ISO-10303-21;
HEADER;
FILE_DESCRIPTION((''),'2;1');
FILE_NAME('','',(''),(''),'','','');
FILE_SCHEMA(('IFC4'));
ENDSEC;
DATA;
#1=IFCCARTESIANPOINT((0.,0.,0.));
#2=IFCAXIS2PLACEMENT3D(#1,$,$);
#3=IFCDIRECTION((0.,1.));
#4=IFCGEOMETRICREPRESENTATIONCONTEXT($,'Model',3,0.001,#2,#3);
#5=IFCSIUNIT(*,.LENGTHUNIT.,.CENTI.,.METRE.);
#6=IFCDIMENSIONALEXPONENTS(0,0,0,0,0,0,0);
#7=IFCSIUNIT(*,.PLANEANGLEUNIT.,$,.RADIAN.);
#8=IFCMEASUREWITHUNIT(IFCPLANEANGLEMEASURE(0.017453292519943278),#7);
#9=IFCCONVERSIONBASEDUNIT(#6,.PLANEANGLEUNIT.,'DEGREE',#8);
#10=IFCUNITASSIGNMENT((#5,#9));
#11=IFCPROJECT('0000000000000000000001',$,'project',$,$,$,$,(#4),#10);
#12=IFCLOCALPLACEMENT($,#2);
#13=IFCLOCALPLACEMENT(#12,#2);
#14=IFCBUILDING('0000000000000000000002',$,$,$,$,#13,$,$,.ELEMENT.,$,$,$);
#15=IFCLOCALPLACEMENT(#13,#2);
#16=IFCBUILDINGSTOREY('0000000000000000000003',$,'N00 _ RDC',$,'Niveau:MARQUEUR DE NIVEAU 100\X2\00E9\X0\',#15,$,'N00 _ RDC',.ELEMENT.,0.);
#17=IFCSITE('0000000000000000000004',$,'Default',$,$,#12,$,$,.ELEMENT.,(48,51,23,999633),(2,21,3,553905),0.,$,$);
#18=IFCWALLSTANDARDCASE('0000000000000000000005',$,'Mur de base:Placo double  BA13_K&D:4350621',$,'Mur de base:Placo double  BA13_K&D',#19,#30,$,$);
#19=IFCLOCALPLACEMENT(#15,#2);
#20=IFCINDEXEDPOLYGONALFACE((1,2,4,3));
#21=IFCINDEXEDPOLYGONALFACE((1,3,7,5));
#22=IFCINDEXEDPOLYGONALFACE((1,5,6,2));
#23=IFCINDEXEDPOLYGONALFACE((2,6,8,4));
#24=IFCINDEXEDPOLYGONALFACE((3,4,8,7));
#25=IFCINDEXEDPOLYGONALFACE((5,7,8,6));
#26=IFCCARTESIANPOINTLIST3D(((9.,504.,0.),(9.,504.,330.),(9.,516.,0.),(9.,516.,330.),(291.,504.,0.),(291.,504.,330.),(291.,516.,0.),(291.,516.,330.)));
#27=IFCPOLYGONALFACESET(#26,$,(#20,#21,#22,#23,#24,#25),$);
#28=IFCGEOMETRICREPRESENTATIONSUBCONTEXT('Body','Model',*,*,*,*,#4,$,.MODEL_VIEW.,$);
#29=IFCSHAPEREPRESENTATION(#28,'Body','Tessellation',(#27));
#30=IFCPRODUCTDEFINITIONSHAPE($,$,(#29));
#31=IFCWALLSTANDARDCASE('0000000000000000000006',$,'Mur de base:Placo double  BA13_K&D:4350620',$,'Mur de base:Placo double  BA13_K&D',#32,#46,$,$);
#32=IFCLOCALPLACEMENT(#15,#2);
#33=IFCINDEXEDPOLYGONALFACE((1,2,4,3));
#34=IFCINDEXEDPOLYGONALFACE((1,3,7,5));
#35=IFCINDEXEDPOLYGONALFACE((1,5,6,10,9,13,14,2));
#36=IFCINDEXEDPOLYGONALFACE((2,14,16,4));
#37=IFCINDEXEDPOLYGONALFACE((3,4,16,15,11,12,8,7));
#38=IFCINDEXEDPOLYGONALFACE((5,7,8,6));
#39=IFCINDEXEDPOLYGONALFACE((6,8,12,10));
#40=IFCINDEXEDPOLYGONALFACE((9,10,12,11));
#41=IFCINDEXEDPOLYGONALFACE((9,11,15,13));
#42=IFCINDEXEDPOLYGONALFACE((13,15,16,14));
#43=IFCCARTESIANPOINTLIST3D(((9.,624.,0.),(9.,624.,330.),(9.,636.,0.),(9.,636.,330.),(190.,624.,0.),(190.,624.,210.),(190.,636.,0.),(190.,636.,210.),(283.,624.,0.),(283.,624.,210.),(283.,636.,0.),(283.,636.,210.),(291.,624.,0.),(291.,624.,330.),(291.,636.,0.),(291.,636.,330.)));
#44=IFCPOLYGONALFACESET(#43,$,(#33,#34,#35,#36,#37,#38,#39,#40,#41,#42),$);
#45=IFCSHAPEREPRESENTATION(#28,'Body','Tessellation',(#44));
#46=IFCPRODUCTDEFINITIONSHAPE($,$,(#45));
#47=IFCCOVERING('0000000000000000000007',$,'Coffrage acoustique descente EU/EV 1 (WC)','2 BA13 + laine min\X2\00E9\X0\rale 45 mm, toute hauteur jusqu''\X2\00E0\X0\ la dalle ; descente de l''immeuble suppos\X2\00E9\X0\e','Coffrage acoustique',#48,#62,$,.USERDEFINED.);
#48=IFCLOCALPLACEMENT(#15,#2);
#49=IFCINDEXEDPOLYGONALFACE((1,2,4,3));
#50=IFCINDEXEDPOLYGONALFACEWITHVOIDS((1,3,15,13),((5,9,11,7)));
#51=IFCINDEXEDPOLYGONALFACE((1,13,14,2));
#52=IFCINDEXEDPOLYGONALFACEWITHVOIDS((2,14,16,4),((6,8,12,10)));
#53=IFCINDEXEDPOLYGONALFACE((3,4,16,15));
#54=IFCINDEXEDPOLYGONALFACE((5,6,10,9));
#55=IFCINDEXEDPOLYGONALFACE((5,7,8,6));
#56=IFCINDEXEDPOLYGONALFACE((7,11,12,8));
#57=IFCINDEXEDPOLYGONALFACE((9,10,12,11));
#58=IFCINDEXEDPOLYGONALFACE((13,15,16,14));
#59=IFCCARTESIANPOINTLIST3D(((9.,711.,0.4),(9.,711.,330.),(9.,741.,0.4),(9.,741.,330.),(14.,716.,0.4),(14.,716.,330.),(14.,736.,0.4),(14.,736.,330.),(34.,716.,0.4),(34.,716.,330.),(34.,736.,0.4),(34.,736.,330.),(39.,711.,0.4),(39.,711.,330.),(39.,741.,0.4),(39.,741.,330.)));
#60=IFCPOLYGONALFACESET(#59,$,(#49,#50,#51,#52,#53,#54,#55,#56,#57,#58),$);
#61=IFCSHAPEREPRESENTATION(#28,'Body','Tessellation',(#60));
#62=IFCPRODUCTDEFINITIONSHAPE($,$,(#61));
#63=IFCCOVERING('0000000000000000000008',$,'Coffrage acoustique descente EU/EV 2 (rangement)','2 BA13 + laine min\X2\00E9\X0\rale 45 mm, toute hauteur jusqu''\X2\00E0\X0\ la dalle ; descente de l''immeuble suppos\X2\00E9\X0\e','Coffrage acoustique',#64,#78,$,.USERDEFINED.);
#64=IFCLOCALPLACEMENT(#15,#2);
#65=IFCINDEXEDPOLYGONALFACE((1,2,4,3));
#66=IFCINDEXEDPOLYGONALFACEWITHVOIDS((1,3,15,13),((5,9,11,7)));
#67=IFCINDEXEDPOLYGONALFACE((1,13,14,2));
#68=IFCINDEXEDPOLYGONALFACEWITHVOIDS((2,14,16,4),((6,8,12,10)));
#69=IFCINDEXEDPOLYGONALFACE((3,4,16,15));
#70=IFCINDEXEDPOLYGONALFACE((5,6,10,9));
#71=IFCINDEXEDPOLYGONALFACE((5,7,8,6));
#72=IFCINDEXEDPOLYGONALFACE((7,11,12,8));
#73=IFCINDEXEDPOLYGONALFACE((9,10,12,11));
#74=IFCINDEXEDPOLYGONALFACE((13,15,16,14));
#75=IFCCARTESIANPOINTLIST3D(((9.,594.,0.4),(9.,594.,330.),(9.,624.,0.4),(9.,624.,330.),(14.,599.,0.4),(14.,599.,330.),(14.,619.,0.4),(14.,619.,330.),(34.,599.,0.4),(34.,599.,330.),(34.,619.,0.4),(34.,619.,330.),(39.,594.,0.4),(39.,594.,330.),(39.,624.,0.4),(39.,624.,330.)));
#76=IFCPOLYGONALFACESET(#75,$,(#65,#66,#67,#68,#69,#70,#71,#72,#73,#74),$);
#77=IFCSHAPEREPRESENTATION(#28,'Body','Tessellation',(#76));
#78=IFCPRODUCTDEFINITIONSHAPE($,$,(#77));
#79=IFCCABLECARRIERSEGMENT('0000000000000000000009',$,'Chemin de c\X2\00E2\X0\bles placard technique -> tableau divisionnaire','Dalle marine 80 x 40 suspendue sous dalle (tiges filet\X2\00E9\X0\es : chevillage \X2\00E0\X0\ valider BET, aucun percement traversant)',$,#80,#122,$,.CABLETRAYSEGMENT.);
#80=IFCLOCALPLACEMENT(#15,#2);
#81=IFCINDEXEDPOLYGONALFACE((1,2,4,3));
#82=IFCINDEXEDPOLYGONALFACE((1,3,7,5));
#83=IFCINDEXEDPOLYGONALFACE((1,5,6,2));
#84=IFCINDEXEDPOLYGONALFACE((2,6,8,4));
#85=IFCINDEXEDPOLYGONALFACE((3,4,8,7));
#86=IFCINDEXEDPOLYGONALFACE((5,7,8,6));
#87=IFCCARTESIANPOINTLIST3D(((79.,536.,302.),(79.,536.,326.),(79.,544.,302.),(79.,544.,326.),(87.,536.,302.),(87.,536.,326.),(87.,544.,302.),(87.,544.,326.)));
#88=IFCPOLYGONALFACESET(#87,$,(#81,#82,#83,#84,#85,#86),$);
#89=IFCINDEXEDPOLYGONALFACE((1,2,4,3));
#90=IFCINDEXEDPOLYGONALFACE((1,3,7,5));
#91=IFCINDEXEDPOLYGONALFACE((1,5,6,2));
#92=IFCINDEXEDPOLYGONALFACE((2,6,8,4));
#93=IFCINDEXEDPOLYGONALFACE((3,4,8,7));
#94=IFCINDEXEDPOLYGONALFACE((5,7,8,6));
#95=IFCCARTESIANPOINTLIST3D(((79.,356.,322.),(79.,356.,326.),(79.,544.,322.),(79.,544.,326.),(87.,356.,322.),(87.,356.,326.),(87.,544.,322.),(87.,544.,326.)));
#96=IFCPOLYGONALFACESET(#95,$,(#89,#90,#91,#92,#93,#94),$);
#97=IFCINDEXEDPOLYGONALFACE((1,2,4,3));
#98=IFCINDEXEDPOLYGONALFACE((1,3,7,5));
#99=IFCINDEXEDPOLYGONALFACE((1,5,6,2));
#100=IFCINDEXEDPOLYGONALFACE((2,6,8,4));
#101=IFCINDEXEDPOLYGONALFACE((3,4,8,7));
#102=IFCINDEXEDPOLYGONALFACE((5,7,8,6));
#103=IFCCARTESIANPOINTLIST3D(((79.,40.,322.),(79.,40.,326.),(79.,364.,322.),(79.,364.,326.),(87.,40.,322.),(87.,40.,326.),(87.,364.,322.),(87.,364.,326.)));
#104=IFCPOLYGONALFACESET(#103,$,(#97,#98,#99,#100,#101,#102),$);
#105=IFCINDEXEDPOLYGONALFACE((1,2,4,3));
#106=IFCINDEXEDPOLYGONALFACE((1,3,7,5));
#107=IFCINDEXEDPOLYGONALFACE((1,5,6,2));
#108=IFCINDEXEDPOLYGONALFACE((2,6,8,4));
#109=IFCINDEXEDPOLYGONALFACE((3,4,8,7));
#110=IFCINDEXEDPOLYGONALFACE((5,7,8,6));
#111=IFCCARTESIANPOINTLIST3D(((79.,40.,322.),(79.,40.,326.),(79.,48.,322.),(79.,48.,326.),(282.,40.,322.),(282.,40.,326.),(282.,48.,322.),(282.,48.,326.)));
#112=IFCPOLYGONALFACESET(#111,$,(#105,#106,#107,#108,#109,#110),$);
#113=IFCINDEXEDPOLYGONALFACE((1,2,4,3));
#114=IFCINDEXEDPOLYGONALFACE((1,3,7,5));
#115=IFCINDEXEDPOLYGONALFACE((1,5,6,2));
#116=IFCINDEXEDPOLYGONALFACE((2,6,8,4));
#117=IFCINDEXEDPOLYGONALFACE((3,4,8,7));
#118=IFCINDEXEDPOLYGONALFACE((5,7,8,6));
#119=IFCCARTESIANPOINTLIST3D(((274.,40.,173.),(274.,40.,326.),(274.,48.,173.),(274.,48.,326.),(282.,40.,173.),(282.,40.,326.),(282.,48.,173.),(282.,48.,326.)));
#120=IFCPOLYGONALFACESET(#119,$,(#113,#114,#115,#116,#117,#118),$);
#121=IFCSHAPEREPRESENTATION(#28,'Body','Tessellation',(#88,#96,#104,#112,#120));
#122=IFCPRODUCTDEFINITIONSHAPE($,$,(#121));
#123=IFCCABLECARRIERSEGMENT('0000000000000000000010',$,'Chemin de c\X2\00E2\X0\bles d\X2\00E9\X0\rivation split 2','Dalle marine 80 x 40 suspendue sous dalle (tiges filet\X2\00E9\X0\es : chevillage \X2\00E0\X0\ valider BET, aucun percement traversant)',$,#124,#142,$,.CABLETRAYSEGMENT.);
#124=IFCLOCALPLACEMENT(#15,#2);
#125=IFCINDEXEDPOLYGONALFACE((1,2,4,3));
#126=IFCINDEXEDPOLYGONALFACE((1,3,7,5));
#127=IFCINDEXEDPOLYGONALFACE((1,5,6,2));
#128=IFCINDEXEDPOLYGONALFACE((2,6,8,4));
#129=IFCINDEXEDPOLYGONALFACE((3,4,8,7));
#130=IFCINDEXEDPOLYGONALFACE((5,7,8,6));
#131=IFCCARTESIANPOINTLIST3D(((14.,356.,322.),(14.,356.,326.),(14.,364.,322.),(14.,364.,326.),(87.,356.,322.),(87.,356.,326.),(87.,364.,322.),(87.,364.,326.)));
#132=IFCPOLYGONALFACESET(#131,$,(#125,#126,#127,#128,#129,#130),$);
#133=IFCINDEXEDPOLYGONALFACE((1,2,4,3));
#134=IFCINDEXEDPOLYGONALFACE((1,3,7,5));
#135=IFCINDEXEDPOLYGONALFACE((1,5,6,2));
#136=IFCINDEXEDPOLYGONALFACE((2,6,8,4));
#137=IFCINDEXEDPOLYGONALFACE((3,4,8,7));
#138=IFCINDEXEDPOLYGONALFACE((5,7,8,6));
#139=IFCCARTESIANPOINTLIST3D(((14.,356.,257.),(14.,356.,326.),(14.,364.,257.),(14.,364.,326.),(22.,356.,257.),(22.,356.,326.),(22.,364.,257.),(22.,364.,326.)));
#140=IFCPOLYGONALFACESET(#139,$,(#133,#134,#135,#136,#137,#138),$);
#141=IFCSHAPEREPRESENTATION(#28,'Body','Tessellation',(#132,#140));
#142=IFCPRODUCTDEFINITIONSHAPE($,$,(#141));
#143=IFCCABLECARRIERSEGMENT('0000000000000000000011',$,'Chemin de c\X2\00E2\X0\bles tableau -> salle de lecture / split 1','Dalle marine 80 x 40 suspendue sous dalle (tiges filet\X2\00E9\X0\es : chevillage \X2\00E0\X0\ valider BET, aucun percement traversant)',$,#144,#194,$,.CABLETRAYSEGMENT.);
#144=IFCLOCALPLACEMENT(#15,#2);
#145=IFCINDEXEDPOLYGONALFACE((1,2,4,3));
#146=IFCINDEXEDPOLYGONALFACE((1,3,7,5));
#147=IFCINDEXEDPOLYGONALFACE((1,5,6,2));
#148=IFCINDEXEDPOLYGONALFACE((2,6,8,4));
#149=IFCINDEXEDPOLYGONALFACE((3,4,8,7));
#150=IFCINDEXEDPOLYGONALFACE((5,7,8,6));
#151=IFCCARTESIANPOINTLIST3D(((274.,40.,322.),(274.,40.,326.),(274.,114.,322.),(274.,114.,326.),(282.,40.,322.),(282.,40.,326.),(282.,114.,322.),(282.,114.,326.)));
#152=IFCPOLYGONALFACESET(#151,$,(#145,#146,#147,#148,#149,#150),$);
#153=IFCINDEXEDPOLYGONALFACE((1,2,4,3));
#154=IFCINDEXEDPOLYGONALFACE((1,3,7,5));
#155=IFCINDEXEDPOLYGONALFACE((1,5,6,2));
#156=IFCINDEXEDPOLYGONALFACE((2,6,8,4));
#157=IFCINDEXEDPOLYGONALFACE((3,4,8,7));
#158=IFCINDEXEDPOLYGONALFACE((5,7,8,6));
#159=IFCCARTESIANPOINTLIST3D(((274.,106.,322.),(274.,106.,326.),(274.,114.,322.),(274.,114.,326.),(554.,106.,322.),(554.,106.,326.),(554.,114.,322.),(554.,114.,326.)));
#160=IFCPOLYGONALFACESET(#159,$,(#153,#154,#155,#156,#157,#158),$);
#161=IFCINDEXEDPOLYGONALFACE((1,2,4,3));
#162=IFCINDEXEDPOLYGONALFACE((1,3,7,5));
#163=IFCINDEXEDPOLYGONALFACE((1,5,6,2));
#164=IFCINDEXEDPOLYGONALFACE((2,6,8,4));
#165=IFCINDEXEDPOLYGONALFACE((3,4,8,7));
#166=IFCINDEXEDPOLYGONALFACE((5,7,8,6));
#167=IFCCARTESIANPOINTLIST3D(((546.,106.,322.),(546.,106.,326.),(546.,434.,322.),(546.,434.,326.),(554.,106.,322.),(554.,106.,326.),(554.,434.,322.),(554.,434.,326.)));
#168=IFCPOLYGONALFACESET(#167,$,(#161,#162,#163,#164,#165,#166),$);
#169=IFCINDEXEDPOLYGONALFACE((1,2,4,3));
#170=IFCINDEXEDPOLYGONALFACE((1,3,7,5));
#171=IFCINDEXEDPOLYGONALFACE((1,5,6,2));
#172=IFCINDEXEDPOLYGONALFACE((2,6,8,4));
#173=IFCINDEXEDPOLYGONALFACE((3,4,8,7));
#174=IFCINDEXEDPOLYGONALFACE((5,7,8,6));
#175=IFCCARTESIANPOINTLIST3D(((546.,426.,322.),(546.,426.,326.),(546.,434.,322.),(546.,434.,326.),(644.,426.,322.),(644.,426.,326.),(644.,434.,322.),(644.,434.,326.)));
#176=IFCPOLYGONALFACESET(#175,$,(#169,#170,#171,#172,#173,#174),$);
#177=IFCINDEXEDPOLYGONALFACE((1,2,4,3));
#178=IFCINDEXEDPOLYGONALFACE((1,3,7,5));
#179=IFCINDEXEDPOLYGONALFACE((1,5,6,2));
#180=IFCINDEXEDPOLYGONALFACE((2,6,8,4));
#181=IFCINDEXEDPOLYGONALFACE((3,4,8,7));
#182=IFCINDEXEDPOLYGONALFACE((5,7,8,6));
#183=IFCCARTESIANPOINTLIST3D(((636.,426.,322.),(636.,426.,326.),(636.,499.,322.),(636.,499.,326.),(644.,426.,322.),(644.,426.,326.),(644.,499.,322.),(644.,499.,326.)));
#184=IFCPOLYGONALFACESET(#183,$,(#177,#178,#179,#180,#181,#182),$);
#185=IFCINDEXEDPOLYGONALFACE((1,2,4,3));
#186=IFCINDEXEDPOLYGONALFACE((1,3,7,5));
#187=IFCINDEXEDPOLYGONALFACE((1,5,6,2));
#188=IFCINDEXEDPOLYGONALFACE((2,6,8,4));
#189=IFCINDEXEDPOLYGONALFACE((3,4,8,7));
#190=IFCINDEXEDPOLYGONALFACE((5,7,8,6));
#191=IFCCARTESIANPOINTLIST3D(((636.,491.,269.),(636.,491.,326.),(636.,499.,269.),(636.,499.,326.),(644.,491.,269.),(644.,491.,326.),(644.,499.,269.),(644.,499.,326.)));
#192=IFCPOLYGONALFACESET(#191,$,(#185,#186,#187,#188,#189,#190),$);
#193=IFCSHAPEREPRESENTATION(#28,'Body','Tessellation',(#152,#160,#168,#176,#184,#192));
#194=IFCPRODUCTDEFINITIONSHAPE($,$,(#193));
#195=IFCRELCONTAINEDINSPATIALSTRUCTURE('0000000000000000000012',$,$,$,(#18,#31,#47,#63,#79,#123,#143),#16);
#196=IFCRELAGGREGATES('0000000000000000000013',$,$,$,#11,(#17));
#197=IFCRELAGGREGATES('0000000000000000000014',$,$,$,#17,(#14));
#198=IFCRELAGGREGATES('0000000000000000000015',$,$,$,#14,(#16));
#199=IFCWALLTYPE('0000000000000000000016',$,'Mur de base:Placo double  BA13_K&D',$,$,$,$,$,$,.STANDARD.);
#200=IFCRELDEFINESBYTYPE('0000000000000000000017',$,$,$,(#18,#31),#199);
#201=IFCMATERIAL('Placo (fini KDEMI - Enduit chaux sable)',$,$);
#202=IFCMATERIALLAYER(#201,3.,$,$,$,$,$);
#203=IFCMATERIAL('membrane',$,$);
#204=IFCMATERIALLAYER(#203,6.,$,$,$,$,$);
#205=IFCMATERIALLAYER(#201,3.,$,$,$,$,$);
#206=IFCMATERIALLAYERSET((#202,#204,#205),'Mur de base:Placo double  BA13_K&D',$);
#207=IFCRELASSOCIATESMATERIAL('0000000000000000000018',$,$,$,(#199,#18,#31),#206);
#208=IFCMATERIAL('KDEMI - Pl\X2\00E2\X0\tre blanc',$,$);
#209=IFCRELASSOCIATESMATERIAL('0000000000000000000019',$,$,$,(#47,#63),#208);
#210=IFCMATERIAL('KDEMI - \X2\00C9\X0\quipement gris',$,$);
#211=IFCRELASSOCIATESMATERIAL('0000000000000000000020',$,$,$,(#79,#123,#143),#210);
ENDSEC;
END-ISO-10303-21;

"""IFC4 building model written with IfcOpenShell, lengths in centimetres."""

from ifc_helpers import new_model, entity, si_unit, converted_unit, direction, frame, frame_2d, origin, origin_with_axes, place, context, subcontext, project, spatial, rectangle, hollow_rectangle, extrude, material, layer, layer_set, layer_usage, type_object, element, save


model = new_model("IFC4")

# Units and contexts
model_context = context("Model", 3, precision=0.001, world=origin(), true_north=direction((0.0, 1.0)))
body_context = subcontext(model_context, "Body", "Model", "MODEL_VIEW")
ifc_project = project(units=[si_unit("LENGTHUNIT", "METRE", prefix="CENTI"), converted_unit("PLANEANGLEUNIT", "DEGREE", entity("IfcPlaneAngleMeasure", 0.017453292519943278), si_unit("PLANEANGLEUNIT", "RADIAN"), dimensions=[0, 0, 0, 0, 0, 0, 0])], contexts=[model_context])

# Site, building, storey
site_placement = place(None, origin())
site = spatial("IfcSite", under=ifc_project, at=site_placement, Name="Default", CompositionType="ELEMENT", RefLatitude=(48, 51, 23, 999633), RefLongitude=(2, 21, 3, 553905), RefElevation=0.0)
building_placement = place(site_placement, origin())
building = spatial("IfcBuilding", under=site, at=building_placement, CompositionType="ELEMENT")
storey_placement = place(building_placement, origin())
storey = spatial("IfcBuildingStorey", under=building, at=storey_placement, Name="N00 _ RDC", ObjectType="Niveau:MARQUEUR DE NIVEAU 100é", LongName="N00 _ RDC", CompositionType="ELEMENT", Elevation=0.0)

# Wall
ifc_material_1 = material(Name="Placo (fini KDEMI - Enduit chaux sable)")
ifc_layer_1 = layer(ifc_material_1, 3.0)
ifc_material_2 = material(Name="membrane")
ifc_layer_2 = layer(ifc_material_2, 6.0)
ifc_layer_3 = layer(ifc_material_1, 3.0)
ifc_layer_set_1 = layer_set([ifc_layer_1, ifc_layer_2, ifc_layer_3], Name="Mur de base:Placo double  BA13_K&D")
ifc_layer_usage_1 = layer_usage(ifc_layer_set_1, "AXIS2", "POSITIVE", -6.0)
wall_type_1 = type_object("IfcWallType", Name="Mur de base:Placo double  BA13_K&D", PredefinedType="STANDARD", material=ifc_layer_set_1)
wall_1_placement = place(storey_placement, frame((9.0, 510.0, 0.0)))
element("IfcWallStandardCase", 1, at=wall_1_placement, inside=storey, type_object=wall_type_1, material=ifc_layer_usage_1, Name="Mur de base:Placo double  BA13_K&D:4350621", ObjectType="Mur de base:Placo double  BA13_K&D", context=body_context, shape_type="SweptSolid", body=[
    extrude(rectangle(XDim=282.0, YDim=12.0, at=frame_2d((141.0, 0.0), x_axis=(-1.0, 0.0))), origin(), (0.0, 0.0, 1.0), 330.0),
])

# Wall, opening
ifc_layer_usage_2 = layer_usage(ifc_layer_set_1, "AXIS2", "NEGATIVE", 6.0)
wall_2_placement = place(storey_placement, frame((9.0, 630.0, 0.0)))
wall_2 = element("IfcWallStandardCase", 2, at=wall_2_placement, inside=storey, type_object=wall_type_1, material=ifc_layer_usage_2, Name="Mur de base:Placo double  BA13_K&D:4350620", ObjectType="Mur de base:Placo double  BA13_K&D", context=body_context, shape_type="SweptSolid", body=[
    extrude(rectangle(XDim=282.0, YDim=12.0, at=frame_2d((141.0, 0.0), x_axis=(-1.0, 0.0))), origin(), (0.0, 0.0, 1.0), 330.0),
])
opening_1_placement = place(wall_2_placement, frame((-9.0, -630.0, 0.0), z_axis=(0.0, 0.0, 1.0), x_axis=(1.0, 0.0, 0.0)))
element("IfcOpeningElement", 3, at=opening_1_placement, inside=storey, cuts=wall_2, context=body_context, shape_type="SweptSolid", body=[
    extrude(rectangle(XDim=93.0, YDim=16.0, at=frame_2d((236.5, 630.0))), origin(), (0.0, 0.0, 1.0), 210.0),
])

# Coverings
ifc_material_3 = material(Name="KDEMI - Plâtre blanc")
covering_1_placement = place(storey_placement, origin_with_axes())
element("IfcCovering", 4, at=covering_1_placement, inside=storey, material=ifc_material_3, Name="Coffrage acoustique descente EU/EV 1 (WC)", Description="2 BA13 + laine minérale 45 mm, toute hauteur jusqu'à la dalle ; descente de l'immeuble supposée", ObjectType="Coffrage acoustique", PredefinedType="USERDEFINED", context=body_context, shape_type="SweptSolid", body=[
    extrude(hollow_rectangle(XDim=30.0, YDim=30.0, WallThickness=5.0, at=frame_2d((24.0, 726.0))), frame((0.0, 0.0, 0.4)), (0.0, 0.0, 1.0), 329.6),
])
covering_2_placement = place(storey_placement, origin_with_axes())
element("IfcCovering", 5, at=covering_2_placement, inside=storey, material=ifc_material_3, Name="Coffrage acoustique descente EU/EV 2 (rangement)", Description="2 BA13 + laine minérale 45 mm, toute hauteur jusqu'à la dalle ; descente de l'immeuble supposée", ObjectType="Coffrage acoustique", PredefinedType="USERDEFINED", context=body_context, shape_type="SweptSolid", body=[
    extrude(hollow_rectangle(XDim=30.0, YDim=30.0, WallThickness=5.0, at=frame_2d((24.0, 609.0))), frame((0.0, 0.0, 0.4)), (0.0, 0.0, 1.0), 329.6),
])

# Cable carrier segments
ifc_material_4 = material(Name="KDEMI - Équipement gris")
cable_carrier_segment_1_placement = place(storey_placement, origin_with_axes())
element("IfcCableCarrierSegment", 6, at=cable_carrier_segment_1_placement, inside=storey, material=ifc_material_4, Name="Chemin de câbles placard technique -> tableau divisionnaire", Description="Dalle marine 80 x 40 suspendue sous dalle (tiges filetées : chevillage à valider BET, aucun percement traversant)", PredefinedType="CABLETRAYSEGMENT", context=body_context, shape_type="SweptSolid", body=[
    extrude(rectangle(XDim=8.0, YDim=8.0, at=frame_2d((83.0, 540.0))), frame((0.0, 0.0, 302.0)), (0.0, 0.0, 1.0), 24.0),
    extrude(rectangle(XDim=8.0, YDim=188.0, at=frame_2d((83.0, 450.0))), frame((0.0, 0.0, 322.0)), (0.0, 0.0, 1.0), 4.0),
    extrude(rectangle(XDim=8.0, YDim=324.0, at=frame_2d((83.0, 202.0))), frame((0.0, 0.0, 322.0)), (0.0, 0.0, 1.0), 4.0),
    extrude(rectangle(XDim=203.0, YDim=8.0, at=frame_2d((180.5, 44.0))), frame((0.0, 0.0, 322.0)), (0.0, 0.0, 1.0), 4.0),
    extrude(rectangle(XDim=8.0, YDim=8.0, at=frame_2d((278.0, 44.0))), frame((0.0, 0.0, 173.0)), (0.0, 0.0, 1.0), 153.0),
])
cable_carrier_segment_2_placement = place(storey_placement, origin_with_axes())
element("IfcCableCarrierSegment", 7, at=cable_carrier_segment_2_placement, inside=storey, material=ifc_material_4, Name="Chemin de câbles dérivation split 2", Description="Dalle marine 80 x 40 suspendue sous dalle (tiges filetées : chevillage à valider BET, aucun percement traversant)", PredefinedType="CABLETRAYSEGMENT", context=body_context, shape_type="SweptSolid", body=[
    extrude(rectangle(XDim=73.0, YDim=8.0, at=frame_2d((50.5, 360.0))), frame((0.0, 0.0, 322.0)), (0.0, 0.0, 1.0), 4.0),
    extrude(rectangle(XDim=8.0, YDim=8.0, at=frame_2d((18.0, 360.0))), frame((0.0, 0.0, 257.0)), (0.0, 0.0, 1.0), 69.0),
])
cable_carrier_segment_3_placement = place(storey_placement, origin_with_axes())
element("IfcCableCarrierSegment", 8, at=cable_carrier_segment_3_placement, inside=storey, material=ifc_material_4, Name="Chemin de câbles tableau -> salle de lecture / split 1", Description="Dalle marine 80 x 40 suspendue sous dalle (tiges filetées : chevillage à valider BET, aucun percement traversant)", PredefinedType="CABLETRAYSEGMENT", context=body_context, shape_type="SweptSolid", body=[
    extrude(rectangle(XDim=8.0, YDim=74.0, at=frame_2d((278.0, 77.0))), frame((0.0, 0.0, 322.0)), (0.0, 0.0, 1.0), 4.0),
    extrude(rectangle(XDim=280.0, YDim=8.0, at=frame_2d((414.0, 110.0))), frame((0.0, 0.0, 322.0)), (0.0, 0.0, 1.0), 4.0),
    extrude(rectangle(XDim=8.0, YDim=328.0, at=frame_2d((550.0, 270.0))), frame((0.0, 0.0, 322.0)), (0.0, 0.0, 1.0), 4.0),
    extrude(rectangle(XDim=98.0, YDim=8.0, at=frame_2d((595.0, 430.0))), frame((0.0, 0.0, 322.0)), (0.0, 0.0, 1.0), 4.0),
    extrude(rectangle(XDim=8.0, YDim=73.0, at=frame_2d((640.0, 462.5))), frame((0.0, 0.0, 322.0)), (0.0, 0.0, 1.0), 4.0),
    extrude(rectangle(XDim=8.0, YDim=8.0, at=frame_2d((640.0, 495.0))), frame((0.0, 0.0, 269.0)), (0.0, 0.0, 1.0), 57.0),
])

save(model, "model.ifc")
